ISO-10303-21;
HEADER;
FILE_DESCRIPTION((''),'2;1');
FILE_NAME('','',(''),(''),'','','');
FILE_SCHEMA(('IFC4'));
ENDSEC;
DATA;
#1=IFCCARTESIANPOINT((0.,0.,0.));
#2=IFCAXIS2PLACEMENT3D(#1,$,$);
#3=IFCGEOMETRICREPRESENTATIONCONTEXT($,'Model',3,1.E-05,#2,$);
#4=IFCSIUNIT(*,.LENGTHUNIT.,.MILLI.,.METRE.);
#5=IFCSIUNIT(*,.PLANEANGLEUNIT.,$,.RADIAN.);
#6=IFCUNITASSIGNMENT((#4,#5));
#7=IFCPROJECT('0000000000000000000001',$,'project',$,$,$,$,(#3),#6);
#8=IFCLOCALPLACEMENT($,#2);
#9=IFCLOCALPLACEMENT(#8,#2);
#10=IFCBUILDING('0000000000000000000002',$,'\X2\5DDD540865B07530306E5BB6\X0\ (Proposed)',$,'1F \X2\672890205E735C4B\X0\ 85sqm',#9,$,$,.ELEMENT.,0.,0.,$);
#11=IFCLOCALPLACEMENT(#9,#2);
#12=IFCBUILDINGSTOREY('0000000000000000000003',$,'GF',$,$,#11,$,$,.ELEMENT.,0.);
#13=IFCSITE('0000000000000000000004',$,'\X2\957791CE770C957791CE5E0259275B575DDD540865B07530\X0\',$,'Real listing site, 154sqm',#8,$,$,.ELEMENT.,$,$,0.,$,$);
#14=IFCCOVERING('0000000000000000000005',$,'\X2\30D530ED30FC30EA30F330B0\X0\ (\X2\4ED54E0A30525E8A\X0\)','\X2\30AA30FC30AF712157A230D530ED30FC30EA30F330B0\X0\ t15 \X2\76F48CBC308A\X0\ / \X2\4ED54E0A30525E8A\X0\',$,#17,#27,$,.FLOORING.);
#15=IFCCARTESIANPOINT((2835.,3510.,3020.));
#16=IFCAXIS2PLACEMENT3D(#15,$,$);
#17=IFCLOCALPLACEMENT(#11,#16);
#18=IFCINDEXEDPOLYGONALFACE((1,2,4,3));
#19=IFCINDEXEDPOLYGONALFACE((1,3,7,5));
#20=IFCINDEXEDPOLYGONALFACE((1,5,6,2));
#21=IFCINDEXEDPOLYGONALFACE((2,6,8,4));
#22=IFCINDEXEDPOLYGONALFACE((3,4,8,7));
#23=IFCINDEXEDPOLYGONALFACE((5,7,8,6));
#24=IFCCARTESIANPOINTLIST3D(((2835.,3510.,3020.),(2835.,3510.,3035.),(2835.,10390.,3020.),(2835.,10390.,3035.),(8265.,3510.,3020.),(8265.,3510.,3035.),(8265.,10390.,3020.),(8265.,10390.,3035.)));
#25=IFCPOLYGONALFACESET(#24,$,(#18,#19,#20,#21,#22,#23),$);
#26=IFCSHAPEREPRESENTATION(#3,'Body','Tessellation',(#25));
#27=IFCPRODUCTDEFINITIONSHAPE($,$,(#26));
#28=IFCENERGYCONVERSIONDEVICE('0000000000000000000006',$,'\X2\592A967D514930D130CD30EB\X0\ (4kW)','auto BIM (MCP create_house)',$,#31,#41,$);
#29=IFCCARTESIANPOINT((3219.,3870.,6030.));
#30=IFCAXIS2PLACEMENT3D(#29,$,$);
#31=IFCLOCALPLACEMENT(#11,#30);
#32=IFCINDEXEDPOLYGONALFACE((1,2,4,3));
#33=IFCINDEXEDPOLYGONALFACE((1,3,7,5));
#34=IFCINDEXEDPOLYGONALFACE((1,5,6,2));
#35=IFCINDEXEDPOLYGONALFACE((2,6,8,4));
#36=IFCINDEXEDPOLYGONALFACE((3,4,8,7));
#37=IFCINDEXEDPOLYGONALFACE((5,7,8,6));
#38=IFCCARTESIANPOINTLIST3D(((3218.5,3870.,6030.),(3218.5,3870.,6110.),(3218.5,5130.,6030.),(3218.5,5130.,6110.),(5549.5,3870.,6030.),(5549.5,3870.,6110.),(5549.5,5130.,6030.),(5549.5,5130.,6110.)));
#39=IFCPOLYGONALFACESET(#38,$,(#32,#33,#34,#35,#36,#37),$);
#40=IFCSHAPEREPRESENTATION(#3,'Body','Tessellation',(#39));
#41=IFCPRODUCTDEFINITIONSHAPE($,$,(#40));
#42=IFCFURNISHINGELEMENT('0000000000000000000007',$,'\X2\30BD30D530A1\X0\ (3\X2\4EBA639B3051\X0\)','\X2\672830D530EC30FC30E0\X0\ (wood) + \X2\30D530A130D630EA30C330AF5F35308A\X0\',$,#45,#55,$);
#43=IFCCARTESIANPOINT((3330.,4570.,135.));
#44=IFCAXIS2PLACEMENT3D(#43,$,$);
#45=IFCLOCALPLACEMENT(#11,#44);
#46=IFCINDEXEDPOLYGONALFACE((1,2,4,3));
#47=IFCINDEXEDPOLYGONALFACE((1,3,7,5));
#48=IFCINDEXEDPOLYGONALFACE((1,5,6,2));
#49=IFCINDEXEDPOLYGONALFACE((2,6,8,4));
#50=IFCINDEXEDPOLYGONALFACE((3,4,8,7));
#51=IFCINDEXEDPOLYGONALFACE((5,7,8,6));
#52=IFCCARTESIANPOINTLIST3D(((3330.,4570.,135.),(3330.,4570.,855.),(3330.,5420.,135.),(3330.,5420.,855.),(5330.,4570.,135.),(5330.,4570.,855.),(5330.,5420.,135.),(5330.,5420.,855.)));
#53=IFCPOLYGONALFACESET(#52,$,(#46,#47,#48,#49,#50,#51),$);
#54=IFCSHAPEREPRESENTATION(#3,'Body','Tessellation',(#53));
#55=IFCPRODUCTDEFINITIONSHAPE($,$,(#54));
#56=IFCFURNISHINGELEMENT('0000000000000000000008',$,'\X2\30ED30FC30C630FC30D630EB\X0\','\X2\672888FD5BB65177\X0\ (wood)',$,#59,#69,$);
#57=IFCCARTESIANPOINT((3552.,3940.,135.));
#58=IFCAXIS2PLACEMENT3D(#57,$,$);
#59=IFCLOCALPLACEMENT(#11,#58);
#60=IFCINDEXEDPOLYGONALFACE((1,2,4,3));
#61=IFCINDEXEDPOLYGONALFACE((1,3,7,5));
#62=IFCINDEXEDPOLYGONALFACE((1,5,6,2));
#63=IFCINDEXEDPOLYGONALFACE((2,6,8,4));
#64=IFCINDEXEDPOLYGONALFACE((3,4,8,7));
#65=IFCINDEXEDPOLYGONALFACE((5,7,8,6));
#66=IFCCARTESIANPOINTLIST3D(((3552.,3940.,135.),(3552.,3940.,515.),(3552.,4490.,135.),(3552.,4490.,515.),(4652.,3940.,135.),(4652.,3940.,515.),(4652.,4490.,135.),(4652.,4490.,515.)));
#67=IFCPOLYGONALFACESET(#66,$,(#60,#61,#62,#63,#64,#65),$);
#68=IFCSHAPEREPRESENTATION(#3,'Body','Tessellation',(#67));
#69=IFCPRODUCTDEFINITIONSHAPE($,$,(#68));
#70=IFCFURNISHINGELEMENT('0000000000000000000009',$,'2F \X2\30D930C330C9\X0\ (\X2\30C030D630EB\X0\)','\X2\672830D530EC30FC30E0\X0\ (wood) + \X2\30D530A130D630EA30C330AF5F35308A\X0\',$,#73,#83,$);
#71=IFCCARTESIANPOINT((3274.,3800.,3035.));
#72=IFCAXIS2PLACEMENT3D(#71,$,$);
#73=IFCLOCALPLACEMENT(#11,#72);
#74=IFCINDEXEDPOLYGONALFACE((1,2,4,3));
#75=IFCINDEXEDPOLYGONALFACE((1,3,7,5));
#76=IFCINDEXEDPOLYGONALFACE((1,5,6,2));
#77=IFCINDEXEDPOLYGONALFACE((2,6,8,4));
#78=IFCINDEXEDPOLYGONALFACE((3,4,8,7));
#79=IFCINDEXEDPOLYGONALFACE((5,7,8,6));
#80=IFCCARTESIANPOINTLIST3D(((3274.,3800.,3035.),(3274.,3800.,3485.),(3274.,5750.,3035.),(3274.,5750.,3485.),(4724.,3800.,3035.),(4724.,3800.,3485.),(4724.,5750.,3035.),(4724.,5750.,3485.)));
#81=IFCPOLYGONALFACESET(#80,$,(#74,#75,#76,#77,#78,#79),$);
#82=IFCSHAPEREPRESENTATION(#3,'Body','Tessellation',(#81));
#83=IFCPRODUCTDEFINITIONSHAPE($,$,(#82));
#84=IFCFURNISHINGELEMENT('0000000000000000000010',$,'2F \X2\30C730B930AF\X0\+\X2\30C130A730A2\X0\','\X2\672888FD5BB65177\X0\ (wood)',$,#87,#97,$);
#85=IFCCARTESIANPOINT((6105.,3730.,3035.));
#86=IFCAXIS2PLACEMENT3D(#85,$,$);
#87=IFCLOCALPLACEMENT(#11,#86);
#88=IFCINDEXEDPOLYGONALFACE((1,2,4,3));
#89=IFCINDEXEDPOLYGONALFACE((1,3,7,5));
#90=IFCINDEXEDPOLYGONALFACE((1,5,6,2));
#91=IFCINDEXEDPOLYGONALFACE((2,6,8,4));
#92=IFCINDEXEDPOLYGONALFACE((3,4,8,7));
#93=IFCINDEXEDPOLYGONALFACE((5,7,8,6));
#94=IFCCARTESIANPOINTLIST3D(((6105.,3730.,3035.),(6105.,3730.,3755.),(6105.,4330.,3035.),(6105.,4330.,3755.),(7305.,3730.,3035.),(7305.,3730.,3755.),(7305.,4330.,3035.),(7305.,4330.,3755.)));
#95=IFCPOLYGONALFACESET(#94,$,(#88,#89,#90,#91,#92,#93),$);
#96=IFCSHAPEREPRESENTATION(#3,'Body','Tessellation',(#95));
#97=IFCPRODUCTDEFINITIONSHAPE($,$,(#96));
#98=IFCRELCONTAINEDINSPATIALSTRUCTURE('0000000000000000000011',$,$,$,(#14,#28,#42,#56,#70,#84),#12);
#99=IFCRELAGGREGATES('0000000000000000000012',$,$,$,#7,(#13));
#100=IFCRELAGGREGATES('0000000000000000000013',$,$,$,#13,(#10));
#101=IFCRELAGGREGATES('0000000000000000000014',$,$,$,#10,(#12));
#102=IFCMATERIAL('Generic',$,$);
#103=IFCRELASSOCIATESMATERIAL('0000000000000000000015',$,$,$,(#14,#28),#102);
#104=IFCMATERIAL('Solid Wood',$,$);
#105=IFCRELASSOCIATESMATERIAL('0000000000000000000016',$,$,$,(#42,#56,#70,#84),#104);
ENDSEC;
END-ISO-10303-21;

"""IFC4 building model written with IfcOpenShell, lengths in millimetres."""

from ifc_helpers import new_model, si_unit, frame, frame_2d, origin, place, context, project, spatial, rectangle, extrude, material, element, save


model = new_model("IFC4")

# Units and contexts
model_context = context("Model", 3, precision=1e-05, world=origin())
ifc_project = project(units=[si_unit("LENGTHUNIT", "METRE", prefix="MILLI"), si_unit("PLANEANGLEUNIT", "RADIAN")], contexts=[model_context])

# Site, building, storey
site_placement = place(None, origin())
site = spatial("IfcSite", under=ifc_project, at=site_placement, Name="長野県長野市大字川合新田", ObjectType="Real listing site, 154sqm", CompositionType="ELEMENT", RefElevation=0.0)
building_placement = place(site_placement, origin())
building = spatial("IfcBuilding", under=site, at=building_placement, Name="川合新田の家 (Proposed)", ObjectType="1F 木造平屋 85sqm", CompositionType="ELEMENT", ElevationOfRefHeight=0.0, ElevationOfTerrain=0.0)
storey_placement = place(building_placement, origin())
storey = spatial("IfcBuildingStorey", under=building, at=storey_placement, Name="GF", CompositionType="ELEMENT", Elevation=0.0)

# Shared definitions
ifc_material_1 = material(Name="Solid Wood")

# Shared definitions
ifc_material_2 = material(Name="Generic")

# Covering
covering_placement = place(storey_placement, frame((2835.0, 3510.0, 3020.0)))
element("IfcCovering", 1, at=covering_placement, inside=storey, material=ifc_material_2, Name="フローリング (仕上げ床)", Description="オーク無垢フローリング t15 直貼り / 仕上げ床", PredefinedType="FLOORING", context=model_context, shape_type="SweptSolid", body=[
    extrude(rectangle(XDim=5430.0, YDim=6880.0, at=frame_2d((2715.0, 3440.0))), frame((2835.0, 3510.0, 3020.0)), (0.0, 0.0, 1.0), 15.0),
])

# Energy conversion device
energy_conversion_device_placement = place(storey_placement, frame((3219.0, 3870.0, 6030.0)))
element("IfcEnergyConversionDevice", 2, at=energy_conversion_device_placement, inside=storey, material=ifc_material_2, Name="太陽光パネル (4kW)", Description="auto BIM (MCP create_house)", context=model_context, shape_type="SweptSolid", body=[
    extrude(rectangle(XDim=2331.0, YDim=1260.0, at=frame_2d((1165.0, 630.0))), frame((3219.0, 3870.0, 6030.0)), (0.0, 0.0, 1.0), 80.0),
])

# Furnishing elements
furnishing_1_placement = place(storey_placement, frame((3330.0, 4570.0, 135.0)))
element("IfcFurnishingElement", 3, at=furnishing_1_placement, inside=storey, material=ifc_material_1, Name="ソファ (3人掛け)", Description="木フレーム (wood) + ファブリック張り", context=model_context, shape_type="SweptSolid", body=[
    extrude(rectangle(XDim=2000.0, YDim=850.0, at=frame_2d((1000.0, 425.0))), frame((3330.0, 4570.0, 135.0)), (0.0, 0.0, 1.0), 720.0),
])
furnishing_2_placement = place(storey_placement, frame((3552.0, 3940.0, 135.0)))
element("IfcFurnishingElement", 4, at=furnishing_2_placement, inside=storey, material=ifc_material_1, Name="ローテーブル", Description="木製家具 (wood)", context=model_context, shape_type="SweptSolid", body=[
    extrude(rectangle(XDim=1100.0, YDim=550.0, at=frame_2d((550.0, 275.0))), frame((3552.0, 3940.0, 135.0)), (0.0, 0.0, 1.0), 380.0),
])
furnishing_3_placement = place(storey_placement, frame((3274.0, 3800.0, 3035.0)))
element("IfcFurnishingElement", 5, at=furnishing_3_placement, inside=storey, material=ifc_material_1, Name="2F ベッド (ダブル)", Description="木フレーム (wood) + ファブリック張り", context=model_context, shape_type="SweptSolid", body=[
    extrude(rectangle(XDim=1450.0, YDim=1950.0, at=frame_2d((725.0, 975.0))), frame((3274.0, 3800.0, 3035.0)), (0.0, 0.0, 1.0), 450.0),
])
furnishing_4_placement = place(storey_placement, frame((6105.0, 3730.0, 3035.0)))
element("IfcFurnishingElement", 6, at=furnishing_4_placement, inside=storey, material=ifc_material_1, Name="2F デスク+チェア", Description="木製家具 (wood)", context=model_context, shape_type="SweptSolid", body=[
    extrude(rectangle(XDim=1200.0, YDim=600.0, at=frame_2d((600.0, 300.0))), frame((6105.0, 3730.0, 3035.0)), (0.0, 0.0, 1.0), 720.0),
])

save(model, "model.ifc")
